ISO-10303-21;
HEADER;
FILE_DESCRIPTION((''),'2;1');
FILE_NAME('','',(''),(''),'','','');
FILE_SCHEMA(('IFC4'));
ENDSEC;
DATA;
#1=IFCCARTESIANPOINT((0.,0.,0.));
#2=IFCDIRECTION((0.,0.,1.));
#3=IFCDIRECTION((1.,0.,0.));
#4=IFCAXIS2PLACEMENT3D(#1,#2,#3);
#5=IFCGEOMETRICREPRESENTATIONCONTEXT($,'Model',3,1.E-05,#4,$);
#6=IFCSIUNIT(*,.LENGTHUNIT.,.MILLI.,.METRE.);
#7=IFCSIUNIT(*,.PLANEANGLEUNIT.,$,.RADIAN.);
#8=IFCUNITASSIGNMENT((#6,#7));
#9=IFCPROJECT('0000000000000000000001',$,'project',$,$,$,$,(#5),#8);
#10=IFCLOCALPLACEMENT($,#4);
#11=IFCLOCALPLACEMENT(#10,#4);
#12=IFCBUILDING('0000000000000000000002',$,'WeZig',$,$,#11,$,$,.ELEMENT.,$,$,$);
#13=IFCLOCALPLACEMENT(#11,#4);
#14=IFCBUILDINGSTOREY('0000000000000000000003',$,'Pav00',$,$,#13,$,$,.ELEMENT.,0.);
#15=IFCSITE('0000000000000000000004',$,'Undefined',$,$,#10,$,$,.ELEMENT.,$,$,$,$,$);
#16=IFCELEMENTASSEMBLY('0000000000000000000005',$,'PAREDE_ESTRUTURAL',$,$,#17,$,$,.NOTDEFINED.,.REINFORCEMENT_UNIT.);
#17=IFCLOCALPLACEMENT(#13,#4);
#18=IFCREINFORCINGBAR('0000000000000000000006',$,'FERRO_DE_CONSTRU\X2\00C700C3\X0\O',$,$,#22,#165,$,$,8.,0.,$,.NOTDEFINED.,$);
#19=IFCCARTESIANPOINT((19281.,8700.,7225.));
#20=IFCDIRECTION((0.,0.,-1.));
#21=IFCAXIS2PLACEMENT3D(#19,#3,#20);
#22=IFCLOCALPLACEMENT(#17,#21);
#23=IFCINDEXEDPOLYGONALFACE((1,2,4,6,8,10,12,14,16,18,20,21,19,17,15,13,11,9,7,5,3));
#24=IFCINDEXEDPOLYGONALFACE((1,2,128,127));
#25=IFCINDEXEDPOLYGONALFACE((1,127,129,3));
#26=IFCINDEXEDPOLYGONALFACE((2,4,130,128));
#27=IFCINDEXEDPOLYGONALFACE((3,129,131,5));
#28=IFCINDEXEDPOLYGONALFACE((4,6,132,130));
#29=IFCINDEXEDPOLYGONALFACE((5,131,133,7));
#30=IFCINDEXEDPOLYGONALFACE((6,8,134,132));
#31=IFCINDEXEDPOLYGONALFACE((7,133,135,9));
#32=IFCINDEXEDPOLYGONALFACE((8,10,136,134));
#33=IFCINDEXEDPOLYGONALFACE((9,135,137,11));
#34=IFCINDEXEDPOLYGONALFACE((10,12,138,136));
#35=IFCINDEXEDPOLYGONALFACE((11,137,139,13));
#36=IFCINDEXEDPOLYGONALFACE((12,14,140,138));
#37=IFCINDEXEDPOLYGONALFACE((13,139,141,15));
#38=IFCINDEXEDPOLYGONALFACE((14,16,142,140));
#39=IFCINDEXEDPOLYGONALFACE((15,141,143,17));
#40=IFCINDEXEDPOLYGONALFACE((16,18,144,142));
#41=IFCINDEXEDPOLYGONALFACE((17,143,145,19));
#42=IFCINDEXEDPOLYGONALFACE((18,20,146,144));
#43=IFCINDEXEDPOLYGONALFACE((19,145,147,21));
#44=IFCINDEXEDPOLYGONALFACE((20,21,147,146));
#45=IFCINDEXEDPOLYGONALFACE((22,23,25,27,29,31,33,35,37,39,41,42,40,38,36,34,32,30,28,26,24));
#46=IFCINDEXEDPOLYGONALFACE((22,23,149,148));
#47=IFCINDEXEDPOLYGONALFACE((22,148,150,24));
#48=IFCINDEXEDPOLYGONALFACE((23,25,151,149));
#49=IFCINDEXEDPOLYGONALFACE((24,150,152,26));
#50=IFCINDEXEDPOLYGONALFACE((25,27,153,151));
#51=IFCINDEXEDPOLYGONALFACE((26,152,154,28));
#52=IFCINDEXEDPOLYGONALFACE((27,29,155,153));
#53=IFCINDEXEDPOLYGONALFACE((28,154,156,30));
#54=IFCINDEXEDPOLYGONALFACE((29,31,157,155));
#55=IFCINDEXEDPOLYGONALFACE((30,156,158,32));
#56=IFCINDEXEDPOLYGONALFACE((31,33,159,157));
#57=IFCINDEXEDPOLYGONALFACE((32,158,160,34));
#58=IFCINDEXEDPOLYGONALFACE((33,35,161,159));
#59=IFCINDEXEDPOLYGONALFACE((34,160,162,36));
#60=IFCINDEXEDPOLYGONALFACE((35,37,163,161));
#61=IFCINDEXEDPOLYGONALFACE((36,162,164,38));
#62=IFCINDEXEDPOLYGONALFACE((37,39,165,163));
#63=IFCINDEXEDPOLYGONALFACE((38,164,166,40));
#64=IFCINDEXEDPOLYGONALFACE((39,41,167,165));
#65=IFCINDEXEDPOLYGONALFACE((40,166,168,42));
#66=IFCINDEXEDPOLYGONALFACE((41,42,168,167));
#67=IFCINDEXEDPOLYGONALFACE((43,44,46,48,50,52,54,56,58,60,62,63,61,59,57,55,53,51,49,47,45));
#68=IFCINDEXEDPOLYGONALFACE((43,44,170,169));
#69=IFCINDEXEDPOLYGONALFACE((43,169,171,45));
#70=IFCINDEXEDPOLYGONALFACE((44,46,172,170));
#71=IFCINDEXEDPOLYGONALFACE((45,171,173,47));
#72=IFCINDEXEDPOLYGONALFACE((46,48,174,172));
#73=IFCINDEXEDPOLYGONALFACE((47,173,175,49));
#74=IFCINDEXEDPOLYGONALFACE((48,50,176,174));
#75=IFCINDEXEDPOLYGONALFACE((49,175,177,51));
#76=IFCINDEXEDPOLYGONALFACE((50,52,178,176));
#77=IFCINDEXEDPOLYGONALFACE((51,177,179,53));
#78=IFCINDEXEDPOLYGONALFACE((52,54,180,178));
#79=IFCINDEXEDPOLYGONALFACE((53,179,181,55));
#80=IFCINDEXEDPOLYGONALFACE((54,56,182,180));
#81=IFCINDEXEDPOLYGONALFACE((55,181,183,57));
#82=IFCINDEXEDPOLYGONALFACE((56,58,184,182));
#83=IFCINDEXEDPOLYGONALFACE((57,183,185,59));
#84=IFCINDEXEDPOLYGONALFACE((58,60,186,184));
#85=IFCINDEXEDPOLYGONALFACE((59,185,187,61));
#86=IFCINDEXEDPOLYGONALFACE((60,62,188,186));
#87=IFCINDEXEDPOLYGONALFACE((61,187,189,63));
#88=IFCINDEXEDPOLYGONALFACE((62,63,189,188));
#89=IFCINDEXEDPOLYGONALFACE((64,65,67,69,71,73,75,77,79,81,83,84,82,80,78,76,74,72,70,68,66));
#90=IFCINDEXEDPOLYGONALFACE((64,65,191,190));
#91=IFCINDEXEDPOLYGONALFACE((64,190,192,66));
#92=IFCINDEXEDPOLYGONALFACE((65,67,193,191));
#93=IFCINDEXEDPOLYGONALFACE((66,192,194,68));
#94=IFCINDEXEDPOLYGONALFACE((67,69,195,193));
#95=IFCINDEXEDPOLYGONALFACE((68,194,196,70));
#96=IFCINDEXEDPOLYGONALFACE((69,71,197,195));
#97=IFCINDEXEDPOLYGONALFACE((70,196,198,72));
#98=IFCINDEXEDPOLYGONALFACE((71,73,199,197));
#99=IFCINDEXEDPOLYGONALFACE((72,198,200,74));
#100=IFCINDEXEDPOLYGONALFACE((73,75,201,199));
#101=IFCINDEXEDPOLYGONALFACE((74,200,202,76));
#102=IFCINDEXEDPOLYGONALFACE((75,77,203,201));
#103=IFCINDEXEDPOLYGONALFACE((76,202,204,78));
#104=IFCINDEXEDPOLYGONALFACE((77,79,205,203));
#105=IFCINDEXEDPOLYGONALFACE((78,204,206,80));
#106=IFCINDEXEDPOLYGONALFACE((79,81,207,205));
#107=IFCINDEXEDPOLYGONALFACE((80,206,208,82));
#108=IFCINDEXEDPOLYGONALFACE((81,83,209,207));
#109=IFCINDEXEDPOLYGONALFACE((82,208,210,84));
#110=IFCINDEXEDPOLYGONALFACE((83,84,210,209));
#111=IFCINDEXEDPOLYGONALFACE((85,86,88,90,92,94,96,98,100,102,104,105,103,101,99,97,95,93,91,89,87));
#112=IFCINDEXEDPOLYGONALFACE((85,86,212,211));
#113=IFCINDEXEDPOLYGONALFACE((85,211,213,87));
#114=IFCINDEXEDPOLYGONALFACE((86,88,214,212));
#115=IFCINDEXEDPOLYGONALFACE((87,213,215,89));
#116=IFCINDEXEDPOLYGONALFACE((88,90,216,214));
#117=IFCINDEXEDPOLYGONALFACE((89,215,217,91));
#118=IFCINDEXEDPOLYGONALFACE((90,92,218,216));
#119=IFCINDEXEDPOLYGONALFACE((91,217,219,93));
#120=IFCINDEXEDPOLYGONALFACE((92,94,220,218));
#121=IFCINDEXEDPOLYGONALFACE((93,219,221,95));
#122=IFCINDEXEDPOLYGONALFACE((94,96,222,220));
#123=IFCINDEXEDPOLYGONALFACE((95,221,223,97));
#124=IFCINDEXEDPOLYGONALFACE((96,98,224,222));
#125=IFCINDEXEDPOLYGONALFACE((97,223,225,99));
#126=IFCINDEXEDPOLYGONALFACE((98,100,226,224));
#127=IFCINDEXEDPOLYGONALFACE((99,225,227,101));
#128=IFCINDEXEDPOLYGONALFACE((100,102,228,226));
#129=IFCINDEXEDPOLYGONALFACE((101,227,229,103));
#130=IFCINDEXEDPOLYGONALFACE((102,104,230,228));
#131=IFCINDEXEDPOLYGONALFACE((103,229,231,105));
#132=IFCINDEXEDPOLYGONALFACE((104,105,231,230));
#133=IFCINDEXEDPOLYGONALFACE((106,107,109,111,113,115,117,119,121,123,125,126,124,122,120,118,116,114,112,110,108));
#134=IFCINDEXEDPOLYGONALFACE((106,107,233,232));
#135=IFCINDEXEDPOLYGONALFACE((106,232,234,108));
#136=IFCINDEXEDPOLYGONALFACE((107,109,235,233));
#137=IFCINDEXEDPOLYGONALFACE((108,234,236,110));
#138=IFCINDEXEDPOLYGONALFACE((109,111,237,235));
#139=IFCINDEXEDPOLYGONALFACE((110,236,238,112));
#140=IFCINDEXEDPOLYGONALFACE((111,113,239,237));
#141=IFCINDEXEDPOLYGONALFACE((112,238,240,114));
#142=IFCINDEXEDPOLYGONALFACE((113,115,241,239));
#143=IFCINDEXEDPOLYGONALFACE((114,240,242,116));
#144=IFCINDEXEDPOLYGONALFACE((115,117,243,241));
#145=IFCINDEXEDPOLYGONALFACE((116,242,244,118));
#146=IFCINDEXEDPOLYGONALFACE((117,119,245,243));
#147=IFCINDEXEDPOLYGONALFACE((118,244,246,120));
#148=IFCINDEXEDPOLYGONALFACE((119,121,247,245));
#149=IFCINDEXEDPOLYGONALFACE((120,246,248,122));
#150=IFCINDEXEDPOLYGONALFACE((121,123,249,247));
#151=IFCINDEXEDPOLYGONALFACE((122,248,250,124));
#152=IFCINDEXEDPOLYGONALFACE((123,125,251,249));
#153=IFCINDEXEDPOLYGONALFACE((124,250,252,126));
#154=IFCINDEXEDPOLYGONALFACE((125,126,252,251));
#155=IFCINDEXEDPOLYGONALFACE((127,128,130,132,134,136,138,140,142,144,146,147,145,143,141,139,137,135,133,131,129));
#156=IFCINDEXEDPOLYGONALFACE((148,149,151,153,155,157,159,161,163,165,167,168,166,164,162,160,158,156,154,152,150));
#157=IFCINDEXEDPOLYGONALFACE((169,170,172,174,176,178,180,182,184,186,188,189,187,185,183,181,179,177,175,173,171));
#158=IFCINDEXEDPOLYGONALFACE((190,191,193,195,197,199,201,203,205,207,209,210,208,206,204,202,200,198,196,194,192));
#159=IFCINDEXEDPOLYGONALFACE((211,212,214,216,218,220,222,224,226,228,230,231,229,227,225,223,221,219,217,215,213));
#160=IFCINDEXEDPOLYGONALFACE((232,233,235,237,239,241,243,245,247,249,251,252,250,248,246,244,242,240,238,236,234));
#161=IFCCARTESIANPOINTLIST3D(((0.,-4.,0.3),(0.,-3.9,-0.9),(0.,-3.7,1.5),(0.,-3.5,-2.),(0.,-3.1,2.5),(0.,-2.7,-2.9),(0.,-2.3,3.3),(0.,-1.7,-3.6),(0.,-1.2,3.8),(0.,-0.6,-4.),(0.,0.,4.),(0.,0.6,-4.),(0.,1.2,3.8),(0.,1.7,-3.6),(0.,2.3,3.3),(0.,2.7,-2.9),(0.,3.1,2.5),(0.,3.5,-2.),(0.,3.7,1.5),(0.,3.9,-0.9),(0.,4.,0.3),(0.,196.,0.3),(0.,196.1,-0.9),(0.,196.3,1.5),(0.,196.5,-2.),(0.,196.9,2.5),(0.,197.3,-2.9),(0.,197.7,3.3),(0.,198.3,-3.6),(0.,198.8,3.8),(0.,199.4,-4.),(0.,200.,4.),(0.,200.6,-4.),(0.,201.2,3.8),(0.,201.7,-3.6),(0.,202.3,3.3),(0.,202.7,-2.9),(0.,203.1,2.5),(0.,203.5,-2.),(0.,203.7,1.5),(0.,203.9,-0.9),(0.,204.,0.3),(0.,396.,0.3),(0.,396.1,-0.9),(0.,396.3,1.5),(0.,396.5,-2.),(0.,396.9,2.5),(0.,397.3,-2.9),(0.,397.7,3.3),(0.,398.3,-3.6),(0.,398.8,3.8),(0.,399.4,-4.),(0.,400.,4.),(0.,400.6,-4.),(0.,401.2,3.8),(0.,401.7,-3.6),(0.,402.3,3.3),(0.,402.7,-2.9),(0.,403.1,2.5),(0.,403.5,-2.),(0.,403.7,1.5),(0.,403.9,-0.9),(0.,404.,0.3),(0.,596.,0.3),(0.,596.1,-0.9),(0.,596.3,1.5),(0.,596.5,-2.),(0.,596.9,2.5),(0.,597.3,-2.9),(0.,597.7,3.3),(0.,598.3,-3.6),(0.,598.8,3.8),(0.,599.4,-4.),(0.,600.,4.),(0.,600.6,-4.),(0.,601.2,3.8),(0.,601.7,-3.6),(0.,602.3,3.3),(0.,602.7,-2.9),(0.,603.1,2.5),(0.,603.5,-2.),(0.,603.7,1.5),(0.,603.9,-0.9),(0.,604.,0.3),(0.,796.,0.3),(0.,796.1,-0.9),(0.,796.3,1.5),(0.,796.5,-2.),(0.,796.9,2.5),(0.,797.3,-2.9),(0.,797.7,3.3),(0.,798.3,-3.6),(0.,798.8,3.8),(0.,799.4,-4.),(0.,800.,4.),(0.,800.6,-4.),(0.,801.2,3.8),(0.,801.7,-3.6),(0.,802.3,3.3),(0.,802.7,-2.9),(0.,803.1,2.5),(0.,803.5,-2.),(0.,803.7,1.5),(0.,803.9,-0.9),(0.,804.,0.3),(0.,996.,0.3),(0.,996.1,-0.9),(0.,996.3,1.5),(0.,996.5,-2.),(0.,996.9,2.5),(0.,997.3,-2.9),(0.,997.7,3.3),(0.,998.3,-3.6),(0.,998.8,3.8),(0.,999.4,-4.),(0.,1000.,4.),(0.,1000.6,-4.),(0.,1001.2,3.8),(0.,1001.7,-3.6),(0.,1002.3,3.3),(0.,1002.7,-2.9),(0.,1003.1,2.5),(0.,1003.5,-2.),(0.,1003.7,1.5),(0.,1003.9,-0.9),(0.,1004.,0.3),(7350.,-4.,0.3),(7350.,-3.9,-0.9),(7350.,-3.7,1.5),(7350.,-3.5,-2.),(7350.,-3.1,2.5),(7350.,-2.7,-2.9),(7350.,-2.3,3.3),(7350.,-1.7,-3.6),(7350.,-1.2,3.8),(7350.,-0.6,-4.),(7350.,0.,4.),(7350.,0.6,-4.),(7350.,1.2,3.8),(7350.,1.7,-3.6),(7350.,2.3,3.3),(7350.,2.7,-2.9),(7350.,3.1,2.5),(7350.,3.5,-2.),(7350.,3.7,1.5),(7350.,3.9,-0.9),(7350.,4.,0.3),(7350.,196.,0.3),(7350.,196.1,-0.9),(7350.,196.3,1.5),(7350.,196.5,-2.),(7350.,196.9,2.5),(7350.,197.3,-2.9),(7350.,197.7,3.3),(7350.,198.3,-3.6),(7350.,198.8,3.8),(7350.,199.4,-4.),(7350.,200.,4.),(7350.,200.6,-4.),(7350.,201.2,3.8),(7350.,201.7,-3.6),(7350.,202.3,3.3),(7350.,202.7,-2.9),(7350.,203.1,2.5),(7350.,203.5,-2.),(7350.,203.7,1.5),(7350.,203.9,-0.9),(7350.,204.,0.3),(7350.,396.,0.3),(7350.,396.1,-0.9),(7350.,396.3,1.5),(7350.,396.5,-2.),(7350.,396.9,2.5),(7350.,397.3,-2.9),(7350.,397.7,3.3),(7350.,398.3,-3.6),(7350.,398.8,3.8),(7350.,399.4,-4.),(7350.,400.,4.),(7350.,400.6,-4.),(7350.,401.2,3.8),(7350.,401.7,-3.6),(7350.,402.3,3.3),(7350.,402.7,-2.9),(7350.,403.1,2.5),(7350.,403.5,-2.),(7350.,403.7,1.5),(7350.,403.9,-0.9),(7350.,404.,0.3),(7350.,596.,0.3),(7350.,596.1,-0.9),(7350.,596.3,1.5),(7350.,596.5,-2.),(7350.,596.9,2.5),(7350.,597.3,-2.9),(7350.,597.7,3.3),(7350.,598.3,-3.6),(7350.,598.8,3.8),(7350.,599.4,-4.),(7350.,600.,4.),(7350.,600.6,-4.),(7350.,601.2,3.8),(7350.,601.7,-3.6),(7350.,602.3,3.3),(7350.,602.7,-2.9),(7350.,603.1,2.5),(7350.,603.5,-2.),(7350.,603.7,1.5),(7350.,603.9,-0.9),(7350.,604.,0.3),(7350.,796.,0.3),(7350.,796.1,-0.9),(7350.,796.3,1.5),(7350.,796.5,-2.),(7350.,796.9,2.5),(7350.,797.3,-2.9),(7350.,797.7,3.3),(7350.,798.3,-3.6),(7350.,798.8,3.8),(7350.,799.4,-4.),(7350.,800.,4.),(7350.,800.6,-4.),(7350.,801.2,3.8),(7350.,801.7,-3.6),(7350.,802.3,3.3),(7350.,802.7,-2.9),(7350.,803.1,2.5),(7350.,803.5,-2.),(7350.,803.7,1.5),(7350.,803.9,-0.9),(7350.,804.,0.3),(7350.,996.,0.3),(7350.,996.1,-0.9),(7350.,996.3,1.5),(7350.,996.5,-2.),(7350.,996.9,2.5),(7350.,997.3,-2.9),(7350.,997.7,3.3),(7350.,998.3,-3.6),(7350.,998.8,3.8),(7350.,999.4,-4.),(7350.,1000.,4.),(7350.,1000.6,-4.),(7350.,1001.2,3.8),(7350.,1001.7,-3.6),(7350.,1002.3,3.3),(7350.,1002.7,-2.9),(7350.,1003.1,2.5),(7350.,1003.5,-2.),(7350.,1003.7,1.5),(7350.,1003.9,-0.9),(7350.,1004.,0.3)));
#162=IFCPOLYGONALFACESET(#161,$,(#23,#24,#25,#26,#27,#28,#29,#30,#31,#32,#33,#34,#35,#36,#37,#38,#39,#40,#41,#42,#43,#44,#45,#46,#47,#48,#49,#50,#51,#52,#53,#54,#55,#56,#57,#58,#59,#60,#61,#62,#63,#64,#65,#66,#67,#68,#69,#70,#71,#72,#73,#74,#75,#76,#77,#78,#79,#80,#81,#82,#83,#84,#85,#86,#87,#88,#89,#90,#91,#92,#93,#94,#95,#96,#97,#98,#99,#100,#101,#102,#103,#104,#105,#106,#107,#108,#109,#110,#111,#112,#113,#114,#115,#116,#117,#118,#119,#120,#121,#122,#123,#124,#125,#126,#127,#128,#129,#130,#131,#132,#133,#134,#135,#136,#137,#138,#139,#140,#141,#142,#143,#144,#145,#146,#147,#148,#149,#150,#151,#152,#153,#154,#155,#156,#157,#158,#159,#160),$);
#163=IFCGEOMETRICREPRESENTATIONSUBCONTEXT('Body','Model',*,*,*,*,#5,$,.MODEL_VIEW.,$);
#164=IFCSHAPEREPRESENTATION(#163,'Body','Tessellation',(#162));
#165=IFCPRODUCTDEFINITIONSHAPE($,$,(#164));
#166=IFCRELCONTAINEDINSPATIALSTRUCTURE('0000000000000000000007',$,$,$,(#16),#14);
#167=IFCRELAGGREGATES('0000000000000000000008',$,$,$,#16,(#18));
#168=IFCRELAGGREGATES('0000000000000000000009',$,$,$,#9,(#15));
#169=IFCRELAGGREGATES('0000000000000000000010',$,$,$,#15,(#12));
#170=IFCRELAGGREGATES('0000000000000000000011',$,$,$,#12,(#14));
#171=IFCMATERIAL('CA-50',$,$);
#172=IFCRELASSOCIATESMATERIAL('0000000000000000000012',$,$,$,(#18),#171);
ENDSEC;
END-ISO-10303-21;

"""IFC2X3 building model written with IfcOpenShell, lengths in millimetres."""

from ifc_helpers import new_model, entity, si_unit, frame, origin_with_axes, place, context, subcontext, project, spatial, source, transform, mapped, material, element, aggregate, save


model = new_model("IFC2X3")

# Units and contexts
model_context = context("Model", 3, precision=1e-05, world=origin_with_axes())
body_context = subcontext(model_context, "Body", "Model", "MODEL_VIEW")
ifc_project = project(units=[si_unit("LENGTHUNIT", "METRE", prefix="MILLI"), si_unit("PLANEANGLEUNIT", "RADIAN")], contexts=[model_context])

# Site, building, storey
site_placement = place(None, origin_with_axes())
site = spatial("IfcSite", under=ifc_project, at=site_placement, Name="Undefined", CompositionType="ELEMENT")
building_placement = place(site_placement, origin_with_axes())
building = spatial("IfcBuilding", under=site, at=building_placement, Name="WeZig", CompositionType="ELEMENT")
storey_placement = place(building_placement, origin_with_axes())
storey = spatial("IfcBuildingStorey", under=building, at=storey_placement, Name="Pav00", CompositionType="ELEMENT", Elevation=0.0)

# Element assembly
assembly_1_placement = place(storey_placement, origin_with_axes())
assembly_1 = element("IfcElementAssembly", 1, at=assembly_1_placement, inside=storey, Name="PAREDE_ESTRUTURAL", AssemblyPlace="NOTDEFINED", PredefinedType="REINFORCEMENT_UNIT")

# Reinforcing bar
ifc_material_1 = material(Name="CA-50")
shared_shape_1 = source(origin_with_axes(), body_context, "Body", "AdvancedSweptSolid", [
    entity("IfcSweptDiskSolid", entity("IfcTrimmedCurve", entity("IfcLine", entity("IfcCartesianPoint", [0.0, 0.0, 0.0]), entity("IfcVector", entity("IfcDirection", [1.0, 0.0, 0.0]), 1.0)), [entity("IfcParameterValue", 0.0)], [entity("IfcParameterValue", 7350.0)], True, "PARAMETER"), 4.0, None, 0.0, 7350.0),
])
shared_shape_2 = source(origin_with_axes(), body_context, "Body", "AdvancedSweptSolid", [
    entity("IfcSweptDiskSolid", entity("IfcTrimmedCurve", entity("IfcLine", entity("IfcCartesianPoint", [0.0, 0.0, 0.0]), entity("IfcVector", entity("IfcDirection", [1.0, 0.0, 0.0]), 1.0)), [entity("IfcParameterValue", 0.0)], [entity("IfcParameterValue", 7350.0)], True, "PARAMETER"), 4.0, None, 0.0, 7350.0),
])
shared_shape_3 = source(origin_with_axes(), body_context, "Body", "AdvancedSweptSolid", [
    entity("IfcSweptDiskSolid", entity("IfcTrimmedCurve", entity("IfcLine", entity("IfcCartesianPoint", [0.0, 0.0, 0.0]), entity("IfcVector", entity("IfcDirection", [1.0, 0.0, 0.0]), 1.0)), [entity("IfcParameterValue", 0.0)], [entity("IfcParameterValue", 7350.0)], True, "PARAMETER"), 4.0, None, 0.0, 7350.0),
])
shared_shape_4 = source(origin_with_axes(), body_context, "Body", "AdvancedSweptSolid", [
    entity("IfcSweptDiskSolid", entity("IfcTrimmedCurve", entity("IfcLine", entity("IfcCartesianPoint", [0.0, 0.0, 0.0]), entity("IfcVector", entity("IfcDirection", [1.0, 0.0, 0.0]), 1.0)), [entity("IfcParameterValue", 0.0)], [entity("IfcParameterValue", 7350.0)], True, "PARAMETER"), 4.0, None, 0.0, 7350.0),
])
shared_shape_5 = source(origin_with_axes(), body_context, "Body", "AdvancedSweptSolid", [
    entity("IfcSweptDiskSolid", entity("IfcTrimmedCurve", entity("IfcLine", entity("IfcCartesianPoint", [0.0, 0.0, 0.0]), entity("IfcVector", entity("IfcDirection", [1.0, 0.0, 0.0]), 1.0)), [entity("IfcParameterValue", 0.0)], [entity("IfcParameterValue", 7350.0)], True, "PARAMETER"), 4.0, None, 0.0, 7350.0),
])
shared_shape_6 = source(origin_with_axes(), body_context, "Body", "AdvancedSweptSolid", [
    entity("IfcSweptDiskSolid", entity("IfcTrimmedCurve", entity("IfcLine", entity("IfcCartesianPoint", [0.0, 0.0, 0.0]), entity("IfcVector", entity("IfcDirection", [1.0, 0.0, 0.0]), 1.0)), [entity("IfcParameterValue", 0.0)], [entity("IfcParameterValue", 7350.0)], True, "PARAMETER"), 4.0, None, 0.0, 7350.0),
])
reinforcing_bar_1_placement = place(assembly_1_placement, frame((19281.0, 8700.0, 7225.0), z_axis=(1.0, 0.0, 0.0), x_axis=(0.0, 0.0, -1.0)))
reinforcing_bar_1 = element("IfcReinforcingBar", 2, at=reinforcing_bar_1_placement, material=ifc_material_1, Name="FERRO_DE_CONSTRUÇÃO", BarRole="NOTDEFINED", CrossSectionArea=0.0, NominalDiameter=8.0, context=body_context, shape_type="MappedRepresentation", body=[
    mapped(shared_shape_1, transform((0.0, 0.0, 0.0))),
    mapped(shared_shape_2, transform((0.0, 200.0, 0.0))),
    mapped(shared_shape_3, transform((0.0, 400.0, 0.0))),
    mapped(shared_shape_4, transform((0.0, 600.0, 0.0))),
    mapped(shared_shape_5, transform((0.0, 800.0, 0.0))),
    mapped(shared_shape_6, transform((0.0, 1000.0, 0.0))),
])
aggregate(assembly_1, [reinforcing_bar_1])

save(model, "model.ifc")
